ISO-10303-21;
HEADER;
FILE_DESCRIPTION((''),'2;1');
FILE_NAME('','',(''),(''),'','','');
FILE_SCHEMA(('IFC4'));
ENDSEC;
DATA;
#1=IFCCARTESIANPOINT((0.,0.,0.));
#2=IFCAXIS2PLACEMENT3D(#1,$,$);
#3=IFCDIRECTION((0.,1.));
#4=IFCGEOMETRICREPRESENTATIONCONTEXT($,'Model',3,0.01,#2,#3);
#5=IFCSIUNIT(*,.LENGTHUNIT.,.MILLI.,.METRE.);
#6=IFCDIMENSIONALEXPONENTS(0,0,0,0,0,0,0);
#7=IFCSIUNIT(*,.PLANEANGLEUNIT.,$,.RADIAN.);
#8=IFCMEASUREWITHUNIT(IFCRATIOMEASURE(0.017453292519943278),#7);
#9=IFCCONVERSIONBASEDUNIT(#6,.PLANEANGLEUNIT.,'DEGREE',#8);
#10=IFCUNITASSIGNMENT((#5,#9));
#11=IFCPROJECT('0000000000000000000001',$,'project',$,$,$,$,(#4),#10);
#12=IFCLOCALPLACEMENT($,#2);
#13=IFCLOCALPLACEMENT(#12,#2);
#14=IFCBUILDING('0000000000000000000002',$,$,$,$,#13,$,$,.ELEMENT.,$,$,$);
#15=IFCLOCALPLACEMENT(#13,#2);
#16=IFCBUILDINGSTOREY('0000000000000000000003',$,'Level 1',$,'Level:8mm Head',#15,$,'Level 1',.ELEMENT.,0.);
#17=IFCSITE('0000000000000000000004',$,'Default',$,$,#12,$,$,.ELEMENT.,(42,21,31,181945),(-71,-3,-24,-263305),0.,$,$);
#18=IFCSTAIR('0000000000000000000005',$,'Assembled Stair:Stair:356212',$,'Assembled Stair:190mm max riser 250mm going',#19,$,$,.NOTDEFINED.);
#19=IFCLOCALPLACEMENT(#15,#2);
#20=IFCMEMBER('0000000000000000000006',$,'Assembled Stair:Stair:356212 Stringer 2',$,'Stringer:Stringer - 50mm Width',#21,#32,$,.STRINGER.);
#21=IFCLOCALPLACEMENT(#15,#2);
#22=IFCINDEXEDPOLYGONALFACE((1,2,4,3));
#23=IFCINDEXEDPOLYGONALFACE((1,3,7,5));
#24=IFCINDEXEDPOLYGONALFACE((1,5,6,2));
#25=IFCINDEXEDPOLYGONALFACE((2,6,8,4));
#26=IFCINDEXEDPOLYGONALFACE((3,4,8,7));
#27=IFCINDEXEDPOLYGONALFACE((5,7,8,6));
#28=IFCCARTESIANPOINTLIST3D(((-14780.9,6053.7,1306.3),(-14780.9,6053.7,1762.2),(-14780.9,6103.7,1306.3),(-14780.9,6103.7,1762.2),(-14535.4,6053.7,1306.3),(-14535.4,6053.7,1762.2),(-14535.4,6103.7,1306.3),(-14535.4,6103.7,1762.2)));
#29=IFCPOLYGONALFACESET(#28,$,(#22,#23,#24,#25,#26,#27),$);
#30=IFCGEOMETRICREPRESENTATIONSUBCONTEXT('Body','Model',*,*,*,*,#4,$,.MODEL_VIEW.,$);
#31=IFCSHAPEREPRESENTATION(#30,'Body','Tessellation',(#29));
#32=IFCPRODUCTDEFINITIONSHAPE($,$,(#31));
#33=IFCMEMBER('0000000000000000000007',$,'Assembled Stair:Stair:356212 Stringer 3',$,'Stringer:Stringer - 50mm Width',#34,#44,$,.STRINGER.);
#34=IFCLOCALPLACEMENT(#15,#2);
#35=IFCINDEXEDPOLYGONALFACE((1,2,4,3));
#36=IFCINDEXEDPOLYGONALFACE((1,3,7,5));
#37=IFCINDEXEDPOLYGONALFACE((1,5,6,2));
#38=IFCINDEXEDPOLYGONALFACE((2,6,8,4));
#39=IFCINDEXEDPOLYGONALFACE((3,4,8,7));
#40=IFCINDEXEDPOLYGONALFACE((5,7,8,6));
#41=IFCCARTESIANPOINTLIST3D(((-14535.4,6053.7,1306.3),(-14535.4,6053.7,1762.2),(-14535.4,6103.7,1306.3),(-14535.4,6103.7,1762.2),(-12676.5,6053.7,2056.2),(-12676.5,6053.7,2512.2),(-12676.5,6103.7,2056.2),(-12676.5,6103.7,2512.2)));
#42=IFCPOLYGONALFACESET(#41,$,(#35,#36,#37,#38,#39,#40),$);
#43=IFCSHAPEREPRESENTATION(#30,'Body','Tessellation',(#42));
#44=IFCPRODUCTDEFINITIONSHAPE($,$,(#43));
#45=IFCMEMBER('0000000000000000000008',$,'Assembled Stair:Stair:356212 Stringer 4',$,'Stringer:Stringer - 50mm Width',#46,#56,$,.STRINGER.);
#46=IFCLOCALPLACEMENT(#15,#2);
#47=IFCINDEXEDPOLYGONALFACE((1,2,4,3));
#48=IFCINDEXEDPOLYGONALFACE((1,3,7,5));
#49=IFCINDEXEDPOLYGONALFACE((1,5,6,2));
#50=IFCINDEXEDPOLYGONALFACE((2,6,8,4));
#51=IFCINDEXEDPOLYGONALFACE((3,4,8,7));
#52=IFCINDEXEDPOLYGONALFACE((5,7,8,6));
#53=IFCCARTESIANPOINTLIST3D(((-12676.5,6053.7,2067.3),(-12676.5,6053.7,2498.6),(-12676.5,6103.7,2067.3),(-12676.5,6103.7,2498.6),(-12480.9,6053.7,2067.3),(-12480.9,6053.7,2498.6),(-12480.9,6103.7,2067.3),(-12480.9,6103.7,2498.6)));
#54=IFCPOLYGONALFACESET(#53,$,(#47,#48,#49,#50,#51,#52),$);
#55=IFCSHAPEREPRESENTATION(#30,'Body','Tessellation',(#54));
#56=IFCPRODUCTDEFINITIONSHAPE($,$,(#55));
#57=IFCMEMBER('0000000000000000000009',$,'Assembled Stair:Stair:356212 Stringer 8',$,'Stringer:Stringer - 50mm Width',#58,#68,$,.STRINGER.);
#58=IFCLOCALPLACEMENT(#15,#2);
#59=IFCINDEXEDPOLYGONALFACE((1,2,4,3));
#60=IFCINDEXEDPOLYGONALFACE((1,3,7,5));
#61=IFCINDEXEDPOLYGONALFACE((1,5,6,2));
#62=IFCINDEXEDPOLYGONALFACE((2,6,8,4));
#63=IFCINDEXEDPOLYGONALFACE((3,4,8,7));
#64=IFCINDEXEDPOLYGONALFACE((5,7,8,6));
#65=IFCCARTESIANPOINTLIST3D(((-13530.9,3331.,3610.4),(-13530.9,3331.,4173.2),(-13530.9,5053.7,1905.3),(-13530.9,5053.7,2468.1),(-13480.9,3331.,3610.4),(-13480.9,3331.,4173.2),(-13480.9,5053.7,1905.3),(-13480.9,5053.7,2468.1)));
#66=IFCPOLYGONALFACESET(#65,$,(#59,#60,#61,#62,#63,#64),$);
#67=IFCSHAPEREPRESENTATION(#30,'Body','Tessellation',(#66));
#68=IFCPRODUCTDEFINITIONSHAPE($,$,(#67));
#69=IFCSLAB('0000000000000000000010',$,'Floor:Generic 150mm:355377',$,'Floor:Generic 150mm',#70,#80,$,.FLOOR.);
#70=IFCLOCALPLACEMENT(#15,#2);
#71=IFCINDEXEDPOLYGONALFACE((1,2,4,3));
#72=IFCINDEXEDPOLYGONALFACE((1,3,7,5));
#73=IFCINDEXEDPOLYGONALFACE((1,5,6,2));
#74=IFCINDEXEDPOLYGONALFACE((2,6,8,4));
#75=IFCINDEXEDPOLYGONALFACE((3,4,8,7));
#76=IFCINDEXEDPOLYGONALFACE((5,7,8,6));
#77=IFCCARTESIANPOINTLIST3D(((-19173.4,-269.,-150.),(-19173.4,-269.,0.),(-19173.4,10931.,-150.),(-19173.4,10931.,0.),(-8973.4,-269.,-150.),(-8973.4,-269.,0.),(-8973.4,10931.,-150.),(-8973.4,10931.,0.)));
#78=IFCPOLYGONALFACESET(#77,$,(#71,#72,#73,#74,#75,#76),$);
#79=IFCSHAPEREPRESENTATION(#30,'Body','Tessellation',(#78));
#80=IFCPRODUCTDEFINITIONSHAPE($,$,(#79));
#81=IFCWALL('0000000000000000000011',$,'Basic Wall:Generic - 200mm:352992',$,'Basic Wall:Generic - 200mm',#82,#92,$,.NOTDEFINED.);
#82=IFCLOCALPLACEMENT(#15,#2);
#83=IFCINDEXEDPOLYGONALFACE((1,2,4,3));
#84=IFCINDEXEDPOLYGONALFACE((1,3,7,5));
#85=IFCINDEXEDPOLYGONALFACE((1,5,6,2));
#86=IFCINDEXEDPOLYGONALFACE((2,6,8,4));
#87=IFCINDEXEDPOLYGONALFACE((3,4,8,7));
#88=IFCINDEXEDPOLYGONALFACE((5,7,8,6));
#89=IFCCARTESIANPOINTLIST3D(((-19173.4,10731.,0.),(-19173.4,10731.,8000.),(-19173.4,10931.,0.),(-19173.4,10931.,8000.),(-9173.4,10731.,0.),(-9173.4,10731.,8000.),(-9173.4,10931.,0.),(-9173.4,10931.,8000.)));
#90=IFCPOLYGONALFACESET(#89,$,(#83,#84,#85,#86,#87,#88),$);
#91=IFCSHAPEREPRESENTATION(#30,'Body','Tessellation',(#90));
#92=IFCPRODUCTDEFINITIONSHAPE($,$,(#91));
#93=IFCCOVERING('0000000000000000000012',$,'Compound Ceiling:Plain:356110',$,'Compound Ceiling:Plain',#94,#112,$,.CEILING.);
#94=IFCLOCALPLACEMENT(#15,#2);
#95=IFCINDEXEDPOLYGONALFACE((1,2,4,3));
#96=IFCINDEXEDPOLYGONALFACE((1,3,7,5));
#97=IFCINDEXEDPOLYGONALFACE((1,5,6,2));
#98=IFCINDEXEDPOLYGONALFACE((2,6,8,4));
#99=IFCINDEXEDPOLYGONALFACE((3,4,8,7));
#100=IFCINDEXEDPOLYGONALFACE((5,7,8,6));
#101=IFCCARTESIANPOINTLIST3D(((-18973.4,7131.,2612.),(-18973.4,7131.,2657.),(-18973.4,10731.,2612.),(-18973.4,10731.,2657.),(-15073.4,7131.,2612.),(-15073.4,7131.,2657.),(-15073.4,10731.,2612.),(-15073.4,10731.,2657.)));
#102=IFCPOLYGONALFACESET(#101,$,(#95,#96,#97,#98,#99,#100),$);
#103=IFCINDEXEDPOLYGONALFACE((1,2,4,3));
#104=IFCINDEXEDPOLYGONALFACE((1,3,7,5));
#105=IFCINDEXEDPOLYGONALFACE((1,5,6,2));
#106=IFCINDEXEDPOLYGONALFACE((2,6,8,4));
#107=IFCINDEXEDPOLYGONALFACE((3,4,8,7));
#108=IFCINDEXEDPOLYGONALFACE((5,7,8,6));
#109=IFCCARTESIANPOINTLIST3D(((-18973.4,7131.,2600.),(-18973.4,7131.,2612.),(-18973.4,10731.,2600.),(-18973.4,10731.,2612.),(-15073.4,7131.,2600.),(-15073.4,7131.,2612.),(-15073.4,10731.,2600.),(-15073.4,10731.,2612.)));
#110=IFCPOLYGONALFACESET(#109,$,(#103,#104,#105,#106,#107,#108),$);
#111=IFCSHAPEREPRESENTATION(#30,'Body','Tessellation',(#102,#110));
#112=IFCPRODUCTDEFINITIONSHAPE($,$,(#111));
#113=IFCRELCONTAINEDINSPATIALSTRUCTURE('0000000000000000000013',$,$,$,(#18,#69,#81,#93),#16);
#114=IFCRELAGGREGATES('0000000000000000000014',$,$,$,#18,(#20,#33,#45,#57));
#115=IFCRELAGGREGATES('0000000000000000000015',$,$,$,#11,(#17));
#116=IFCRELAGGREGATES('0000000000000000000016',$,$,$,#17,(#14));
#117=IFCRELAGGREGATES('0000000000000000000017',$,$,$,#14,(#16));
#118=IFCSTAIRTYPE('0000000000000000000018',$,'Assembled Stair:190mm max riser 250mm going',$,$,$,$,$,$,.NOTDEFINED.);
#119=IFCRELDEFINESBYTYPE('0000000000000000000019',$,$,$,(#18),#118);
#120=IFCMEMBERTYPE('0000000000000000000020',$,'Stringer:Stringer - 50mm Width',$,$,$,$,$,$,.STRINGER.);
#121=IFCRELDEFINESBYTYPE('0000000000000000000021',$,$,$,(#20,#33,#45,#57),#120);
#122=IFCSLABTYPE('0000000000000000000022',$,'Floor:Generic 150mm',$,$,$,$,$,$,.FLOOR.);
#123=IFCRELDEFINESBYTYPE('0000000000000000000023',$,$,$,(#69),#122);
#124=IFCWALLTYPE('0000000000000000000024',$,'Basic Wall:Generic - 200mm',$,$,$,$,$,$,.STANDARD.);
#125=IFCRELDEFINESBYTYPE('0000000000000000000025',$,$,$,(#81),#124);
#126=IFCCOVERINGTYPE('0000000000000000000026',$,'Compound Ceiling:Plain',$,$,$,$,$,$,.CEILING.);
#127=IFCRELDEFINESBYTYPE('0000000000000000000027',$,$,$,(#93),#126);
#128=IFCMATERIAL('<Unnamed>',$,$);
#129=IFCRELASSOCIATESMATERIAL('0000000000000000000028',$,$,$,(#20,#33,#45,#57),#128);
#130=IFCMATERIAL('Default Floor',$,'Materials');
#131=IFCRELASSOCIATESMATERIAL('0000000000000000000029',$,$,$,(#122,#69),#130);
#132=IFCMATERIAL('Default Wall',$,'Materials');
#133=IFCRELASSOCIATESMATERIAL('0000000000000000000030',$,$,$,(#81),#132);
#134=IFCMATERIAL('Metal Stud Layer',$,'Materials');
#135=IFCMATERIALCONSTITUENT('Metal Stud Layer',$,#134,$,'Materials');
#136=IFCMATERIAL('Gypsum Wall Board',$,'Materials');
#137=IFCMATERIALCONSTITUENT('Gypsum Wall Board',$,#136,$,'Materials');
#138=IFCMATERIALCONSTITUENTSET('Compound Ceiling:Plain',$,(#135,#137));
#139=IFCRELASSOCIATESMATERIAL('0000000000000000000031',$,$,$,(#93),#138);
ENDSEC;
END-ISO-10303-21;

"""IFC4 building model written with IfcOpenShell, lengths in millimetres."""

from ifc_helpers import new_model, entity, si_unit, converted_unit, direction, frame, origin, place, context, subcontext, project, spatial, indexed_curve, outline, extrude, material, constituent, constituent_set, type_object, element, aggregate, save


model = new_model("IFC4")

# Units and contexts
model_context = context("Model", 3, precision=0.01, world=origin(), true_north=direction((0.0, 1.0)))
body_context = subcontext(model_context, "Body", "Model", "MODEL_VIEW")
ifc_project = project(units=[si_unit("LENGTHUNIT", "METRE", prefix="MILLI"), converted_unit("PLANEANGLEUNIT", "DEGREE", entity("IfcRatioMeasure", 0.017453292519943278), si_unit("PLANEANGLEUNIT", "RADIAN"), dimensions=[0, 0, 0, 0, 0, 0, 0])], contexts=[model_context])

# Site, building, storey
site_placement = place(None, origin())
site = spatial("IfcSite", under=ifc_project, at=site_placement, Name="Default", CompositionType="ELEMENT", RefLatitude=(42, 21, 31, 181945), RefLongitude=(-71, -3, -24, -263305), RefElevation=0.0)
building_placement = place(site_placement, origin())
building = spatial("IfcBuilding", under=site, at=building_placement, CompositionType="ELEMENT")
storey_placement = place(building_placement, origin())
storey = spatial("IfcBuildingStorey", under=building, at=storey_placement, Name="Level 1", ObjectType="Level:8mm Head", LongName="Level 1", CompositionType="ELEMENT", Elevation=0.0)

# Stair, members
stair_type = type_object("IfcStairType", Name="Assembled Stair:190mm max riser 250mm going", PredefinedType="NOTDEFINED")
stair_placement = place(storey_placement, origin())
stair = element("IfcStair", 1, at=stair_placement, inside=storey, type_object=stair_type, Name="Assembled Stair:Stair:356212", ObjectType="Assembled Stair:190mm max riser 250mm going", PredefinedType="NOTDEFINED")
ifc_material_1 = material(Name="<Unnamed>")
member_type = type_object("IfcMemberType", Name="Stringer:Stringer - 50mm Width", PredefinedType="STRINGER")
member_1_placement = place(stair_placement, origin())
member_1 = element("IfcMember", 2, at=member_1_placement, type_object=member_type, material=ifc_material_1, Name="Assembled Stair:Stair:356212 Stringer 2", ObjectType="Stringer:Stringer - 50mm Width", PredefinedType="STRINGER", context=body_context, shape_type="SweptSolid", body=[
    extrude(outline(indexed_curve([(-122.8, -25.0), (122.8, -25.0), (122.8, 25.0), (-122.8, 25.0), (-122.8, -25.0)], self_intersect=False)), frame((-14658.2, 6078.7, 1306.3)), (0.0, 0.0, 1.0), 455.9),
])
member_2_placement = place(stair_placement, origin())
member_2 = element("IfcMember", 3, at=member_2_placement, type_object=member_type, material=ifc_material_1, Name="Assembled Stair:Stair:356212 Stringer 3", ObjectType="Stringer:Stringer - 50mm Width", PredefinedType="STRINGER", context=body_context, shape_type="SweptSolid", body=[
    extrude(outline(indexed_curve([(-917.0, -211.4), (1087.5, -211.4), (917.0, 211.4), (-1087.5, 211.4), (-917.0, -211.4)], self_intersect=False)), frame((-13605.9, 6053.7, 1909.2), z_axis=(0.0, 1.0, 0.0), x_axis=(0.927382, 0.0, 0.374115)), (0.0, 0.0, 1.0), 50.0),
])
member_3_placement = place(stair_placement, origin())
member_3 = element("IfcMember", 4, at=member_3_placement, type_object=member_type, material=ifc_material_1, Name="Assembled Stair:Stair:356212 Stringer 4", ObjectType="Stringer:Stringer - 50mm Width", PredefinedType="STRINGER", context=body_context, shape_type="SweptSolid", body=[
    extrude(outline(indexed_curve([(-97.8, -25.0), (97.8, -25.0), (97.8, 25.0), (-97.8, 25.0), (-97.8, -25.0)], self_intersect=False)), frame((-12578.7, 6078.7, 2067.3)), (0.0, 0.0, 1.0), 431.3),
])
member_4_placement = place(stair_placement, origin())
member_4 = element("IfcMember", 5, at=member_4_placement, type_object=member_type, material=ifc_material_1, Name="Assembled Stair:Stair:356212 Stringer 8", ObjectType="Stringer:Stringer - 50mm Width", PredefinedType="STRINGER", context=body_context, shape_type="SweptSolid", body=[
    extrude(outline(indexed_curve([(-1014.0, -200.0), (1409.9, -200.0), (1014.0, 200.0), (-1409.9, 200.0), (-1014.0, -200.0)], self_intersect=False)), frame((-13530.9, 4192.3, 3039.2), z_axis=(1.0, 0.0, 0.0), x_axis=(0.0, -0.710714, 0.703481)), (0.0, 0.0, 1.0), 50.0),
])

# Slab
ifc_material_2 = material(Name="Default Floor", Category="Materials")
slab_type = type_object("IfcSlabType", Name="Floor:Generic 150mm", PredefinedType="FLOOR", material=ifc_material_2)
slab_placement = place(storey_placement, origin())
element("IfcSlab", 6, at=slab_placement, inside=storey, type_object=slab_type, material=ifc_material_2, Name="Floor:Generic 150mm:355377", ObjectType="Floor:Generic 150mm", PredefinedType="FLOOR", context=body_context, shape_type="SweptSolid", body=[
    extrude(outline(indexed_curve([(-5600.0, -5100.0), (5600.0, -5100.0), (5600.0, 5100.0), (-5600.0, 5100.0), (-5600.0, -5100.0)], self_intersect=False)), frame((-14073.4, 5331.0, 0.0), z_axis=(0.0, 0.0, -1.0), x_axis=(0.0, 1.0, 0.0)), (0.0, 0.0, 1.0), 150.0),
])

# Wall
ifc_material_3 = material(Name="Default Wall", Category="Materials")
wall_type = type_object("IfcWallType", Name="Basic Wall:Generic - 200mm", PredefinedType="STANDARD")
wall_placement = place(storey_placement, frame((-9173.4, 10831.0, 0.0), z_axis=(0.0, 0.0, 1.0), x_axis=(-1.0, 0.0, 0.0)))
element("IfcWall", 7, at=wall_placement, inside=storey, type_object=wall_type, material=ifc_material_3, Name="Basic Wall:Generic - 200mm:352992", ObjectType="Basic Wall:Generic - 200mm", PredefinedType="NOTDEFINED", context=body_context, shape_type="SweptSolid", body=[
    extrude(outline(indexed_curve([(10000.0, 100.0), (0.0, 100.0), (0.0, -100.0), (10000.0, -100.0), (10000.0, 100.0)], self_intersect=False)), origin(), (0.0, 0.0, 1.0), 8000.0),
])

aggregate(stair, [member_1, member_2, member_3, member_4])

# Covering
ifc_material_4 = material(Name="Metal Stud Layer", Category="Materials")
ifc_constituent_1 = constituent(ifc_material_4, Name="Metal Stud Layer", Category="Materials")
ifc_material_5 = material(Name="Gypsum Wall Board", Category="Materials")
ifc_constituent_2 = constituent(ifc_material_5, Name="Gypsum Wall Board", Category="Materials")
ifc_constituent_set = constituent_set(constituents=[ifc_constituent_1, ifc_constituent_2], Name="Compound Ceiling:Plain")
covering_type = type_object("IfcCoveringType", Name="Compound Ceiling:Plain", PredefinedType="CEILING")
covering_placement = place(storey_placement, origin())
element("IfcCovering", 8, at=covering_placement, inside=storey, type_object=covering_type, material=ifc_constituent_set, Name="Compound Ceiling:Plain:356110", ObjectType="Compound Ceiling:Plain", PredefinedType="CEILING", context=body_context, shape_type="SweptSolid", body=[
    extrude(outline(indexed_curve([(-1800.0, -1950.0), (1800.0, -1950.0), (1800.0, 1950.0), (-1800.0, 1950.0), (-1800.0, -1950.0)], self_intersect=False)), frame((-17023.4, 8931.0, 2612.0), z_axis=(0.0, 0.0, 1.0), x_axis=(0.0, 1.0, 0.0)), (0.0, 0.0, 1.0), 45.0),
    extrude(outline(indexed_curve([(-1950.0, -1800.0), (1950.0, -1800.0), (1950.0, 1800.0), (-1950.0, 1800.0), (-1950.0, -1800.0)], self_intersect=False)), frame((-17023.4, 8931.0, 2600.0)), (0.0, 0.0, 1.0), 12.0),
])

save(model, "model.ifc")
